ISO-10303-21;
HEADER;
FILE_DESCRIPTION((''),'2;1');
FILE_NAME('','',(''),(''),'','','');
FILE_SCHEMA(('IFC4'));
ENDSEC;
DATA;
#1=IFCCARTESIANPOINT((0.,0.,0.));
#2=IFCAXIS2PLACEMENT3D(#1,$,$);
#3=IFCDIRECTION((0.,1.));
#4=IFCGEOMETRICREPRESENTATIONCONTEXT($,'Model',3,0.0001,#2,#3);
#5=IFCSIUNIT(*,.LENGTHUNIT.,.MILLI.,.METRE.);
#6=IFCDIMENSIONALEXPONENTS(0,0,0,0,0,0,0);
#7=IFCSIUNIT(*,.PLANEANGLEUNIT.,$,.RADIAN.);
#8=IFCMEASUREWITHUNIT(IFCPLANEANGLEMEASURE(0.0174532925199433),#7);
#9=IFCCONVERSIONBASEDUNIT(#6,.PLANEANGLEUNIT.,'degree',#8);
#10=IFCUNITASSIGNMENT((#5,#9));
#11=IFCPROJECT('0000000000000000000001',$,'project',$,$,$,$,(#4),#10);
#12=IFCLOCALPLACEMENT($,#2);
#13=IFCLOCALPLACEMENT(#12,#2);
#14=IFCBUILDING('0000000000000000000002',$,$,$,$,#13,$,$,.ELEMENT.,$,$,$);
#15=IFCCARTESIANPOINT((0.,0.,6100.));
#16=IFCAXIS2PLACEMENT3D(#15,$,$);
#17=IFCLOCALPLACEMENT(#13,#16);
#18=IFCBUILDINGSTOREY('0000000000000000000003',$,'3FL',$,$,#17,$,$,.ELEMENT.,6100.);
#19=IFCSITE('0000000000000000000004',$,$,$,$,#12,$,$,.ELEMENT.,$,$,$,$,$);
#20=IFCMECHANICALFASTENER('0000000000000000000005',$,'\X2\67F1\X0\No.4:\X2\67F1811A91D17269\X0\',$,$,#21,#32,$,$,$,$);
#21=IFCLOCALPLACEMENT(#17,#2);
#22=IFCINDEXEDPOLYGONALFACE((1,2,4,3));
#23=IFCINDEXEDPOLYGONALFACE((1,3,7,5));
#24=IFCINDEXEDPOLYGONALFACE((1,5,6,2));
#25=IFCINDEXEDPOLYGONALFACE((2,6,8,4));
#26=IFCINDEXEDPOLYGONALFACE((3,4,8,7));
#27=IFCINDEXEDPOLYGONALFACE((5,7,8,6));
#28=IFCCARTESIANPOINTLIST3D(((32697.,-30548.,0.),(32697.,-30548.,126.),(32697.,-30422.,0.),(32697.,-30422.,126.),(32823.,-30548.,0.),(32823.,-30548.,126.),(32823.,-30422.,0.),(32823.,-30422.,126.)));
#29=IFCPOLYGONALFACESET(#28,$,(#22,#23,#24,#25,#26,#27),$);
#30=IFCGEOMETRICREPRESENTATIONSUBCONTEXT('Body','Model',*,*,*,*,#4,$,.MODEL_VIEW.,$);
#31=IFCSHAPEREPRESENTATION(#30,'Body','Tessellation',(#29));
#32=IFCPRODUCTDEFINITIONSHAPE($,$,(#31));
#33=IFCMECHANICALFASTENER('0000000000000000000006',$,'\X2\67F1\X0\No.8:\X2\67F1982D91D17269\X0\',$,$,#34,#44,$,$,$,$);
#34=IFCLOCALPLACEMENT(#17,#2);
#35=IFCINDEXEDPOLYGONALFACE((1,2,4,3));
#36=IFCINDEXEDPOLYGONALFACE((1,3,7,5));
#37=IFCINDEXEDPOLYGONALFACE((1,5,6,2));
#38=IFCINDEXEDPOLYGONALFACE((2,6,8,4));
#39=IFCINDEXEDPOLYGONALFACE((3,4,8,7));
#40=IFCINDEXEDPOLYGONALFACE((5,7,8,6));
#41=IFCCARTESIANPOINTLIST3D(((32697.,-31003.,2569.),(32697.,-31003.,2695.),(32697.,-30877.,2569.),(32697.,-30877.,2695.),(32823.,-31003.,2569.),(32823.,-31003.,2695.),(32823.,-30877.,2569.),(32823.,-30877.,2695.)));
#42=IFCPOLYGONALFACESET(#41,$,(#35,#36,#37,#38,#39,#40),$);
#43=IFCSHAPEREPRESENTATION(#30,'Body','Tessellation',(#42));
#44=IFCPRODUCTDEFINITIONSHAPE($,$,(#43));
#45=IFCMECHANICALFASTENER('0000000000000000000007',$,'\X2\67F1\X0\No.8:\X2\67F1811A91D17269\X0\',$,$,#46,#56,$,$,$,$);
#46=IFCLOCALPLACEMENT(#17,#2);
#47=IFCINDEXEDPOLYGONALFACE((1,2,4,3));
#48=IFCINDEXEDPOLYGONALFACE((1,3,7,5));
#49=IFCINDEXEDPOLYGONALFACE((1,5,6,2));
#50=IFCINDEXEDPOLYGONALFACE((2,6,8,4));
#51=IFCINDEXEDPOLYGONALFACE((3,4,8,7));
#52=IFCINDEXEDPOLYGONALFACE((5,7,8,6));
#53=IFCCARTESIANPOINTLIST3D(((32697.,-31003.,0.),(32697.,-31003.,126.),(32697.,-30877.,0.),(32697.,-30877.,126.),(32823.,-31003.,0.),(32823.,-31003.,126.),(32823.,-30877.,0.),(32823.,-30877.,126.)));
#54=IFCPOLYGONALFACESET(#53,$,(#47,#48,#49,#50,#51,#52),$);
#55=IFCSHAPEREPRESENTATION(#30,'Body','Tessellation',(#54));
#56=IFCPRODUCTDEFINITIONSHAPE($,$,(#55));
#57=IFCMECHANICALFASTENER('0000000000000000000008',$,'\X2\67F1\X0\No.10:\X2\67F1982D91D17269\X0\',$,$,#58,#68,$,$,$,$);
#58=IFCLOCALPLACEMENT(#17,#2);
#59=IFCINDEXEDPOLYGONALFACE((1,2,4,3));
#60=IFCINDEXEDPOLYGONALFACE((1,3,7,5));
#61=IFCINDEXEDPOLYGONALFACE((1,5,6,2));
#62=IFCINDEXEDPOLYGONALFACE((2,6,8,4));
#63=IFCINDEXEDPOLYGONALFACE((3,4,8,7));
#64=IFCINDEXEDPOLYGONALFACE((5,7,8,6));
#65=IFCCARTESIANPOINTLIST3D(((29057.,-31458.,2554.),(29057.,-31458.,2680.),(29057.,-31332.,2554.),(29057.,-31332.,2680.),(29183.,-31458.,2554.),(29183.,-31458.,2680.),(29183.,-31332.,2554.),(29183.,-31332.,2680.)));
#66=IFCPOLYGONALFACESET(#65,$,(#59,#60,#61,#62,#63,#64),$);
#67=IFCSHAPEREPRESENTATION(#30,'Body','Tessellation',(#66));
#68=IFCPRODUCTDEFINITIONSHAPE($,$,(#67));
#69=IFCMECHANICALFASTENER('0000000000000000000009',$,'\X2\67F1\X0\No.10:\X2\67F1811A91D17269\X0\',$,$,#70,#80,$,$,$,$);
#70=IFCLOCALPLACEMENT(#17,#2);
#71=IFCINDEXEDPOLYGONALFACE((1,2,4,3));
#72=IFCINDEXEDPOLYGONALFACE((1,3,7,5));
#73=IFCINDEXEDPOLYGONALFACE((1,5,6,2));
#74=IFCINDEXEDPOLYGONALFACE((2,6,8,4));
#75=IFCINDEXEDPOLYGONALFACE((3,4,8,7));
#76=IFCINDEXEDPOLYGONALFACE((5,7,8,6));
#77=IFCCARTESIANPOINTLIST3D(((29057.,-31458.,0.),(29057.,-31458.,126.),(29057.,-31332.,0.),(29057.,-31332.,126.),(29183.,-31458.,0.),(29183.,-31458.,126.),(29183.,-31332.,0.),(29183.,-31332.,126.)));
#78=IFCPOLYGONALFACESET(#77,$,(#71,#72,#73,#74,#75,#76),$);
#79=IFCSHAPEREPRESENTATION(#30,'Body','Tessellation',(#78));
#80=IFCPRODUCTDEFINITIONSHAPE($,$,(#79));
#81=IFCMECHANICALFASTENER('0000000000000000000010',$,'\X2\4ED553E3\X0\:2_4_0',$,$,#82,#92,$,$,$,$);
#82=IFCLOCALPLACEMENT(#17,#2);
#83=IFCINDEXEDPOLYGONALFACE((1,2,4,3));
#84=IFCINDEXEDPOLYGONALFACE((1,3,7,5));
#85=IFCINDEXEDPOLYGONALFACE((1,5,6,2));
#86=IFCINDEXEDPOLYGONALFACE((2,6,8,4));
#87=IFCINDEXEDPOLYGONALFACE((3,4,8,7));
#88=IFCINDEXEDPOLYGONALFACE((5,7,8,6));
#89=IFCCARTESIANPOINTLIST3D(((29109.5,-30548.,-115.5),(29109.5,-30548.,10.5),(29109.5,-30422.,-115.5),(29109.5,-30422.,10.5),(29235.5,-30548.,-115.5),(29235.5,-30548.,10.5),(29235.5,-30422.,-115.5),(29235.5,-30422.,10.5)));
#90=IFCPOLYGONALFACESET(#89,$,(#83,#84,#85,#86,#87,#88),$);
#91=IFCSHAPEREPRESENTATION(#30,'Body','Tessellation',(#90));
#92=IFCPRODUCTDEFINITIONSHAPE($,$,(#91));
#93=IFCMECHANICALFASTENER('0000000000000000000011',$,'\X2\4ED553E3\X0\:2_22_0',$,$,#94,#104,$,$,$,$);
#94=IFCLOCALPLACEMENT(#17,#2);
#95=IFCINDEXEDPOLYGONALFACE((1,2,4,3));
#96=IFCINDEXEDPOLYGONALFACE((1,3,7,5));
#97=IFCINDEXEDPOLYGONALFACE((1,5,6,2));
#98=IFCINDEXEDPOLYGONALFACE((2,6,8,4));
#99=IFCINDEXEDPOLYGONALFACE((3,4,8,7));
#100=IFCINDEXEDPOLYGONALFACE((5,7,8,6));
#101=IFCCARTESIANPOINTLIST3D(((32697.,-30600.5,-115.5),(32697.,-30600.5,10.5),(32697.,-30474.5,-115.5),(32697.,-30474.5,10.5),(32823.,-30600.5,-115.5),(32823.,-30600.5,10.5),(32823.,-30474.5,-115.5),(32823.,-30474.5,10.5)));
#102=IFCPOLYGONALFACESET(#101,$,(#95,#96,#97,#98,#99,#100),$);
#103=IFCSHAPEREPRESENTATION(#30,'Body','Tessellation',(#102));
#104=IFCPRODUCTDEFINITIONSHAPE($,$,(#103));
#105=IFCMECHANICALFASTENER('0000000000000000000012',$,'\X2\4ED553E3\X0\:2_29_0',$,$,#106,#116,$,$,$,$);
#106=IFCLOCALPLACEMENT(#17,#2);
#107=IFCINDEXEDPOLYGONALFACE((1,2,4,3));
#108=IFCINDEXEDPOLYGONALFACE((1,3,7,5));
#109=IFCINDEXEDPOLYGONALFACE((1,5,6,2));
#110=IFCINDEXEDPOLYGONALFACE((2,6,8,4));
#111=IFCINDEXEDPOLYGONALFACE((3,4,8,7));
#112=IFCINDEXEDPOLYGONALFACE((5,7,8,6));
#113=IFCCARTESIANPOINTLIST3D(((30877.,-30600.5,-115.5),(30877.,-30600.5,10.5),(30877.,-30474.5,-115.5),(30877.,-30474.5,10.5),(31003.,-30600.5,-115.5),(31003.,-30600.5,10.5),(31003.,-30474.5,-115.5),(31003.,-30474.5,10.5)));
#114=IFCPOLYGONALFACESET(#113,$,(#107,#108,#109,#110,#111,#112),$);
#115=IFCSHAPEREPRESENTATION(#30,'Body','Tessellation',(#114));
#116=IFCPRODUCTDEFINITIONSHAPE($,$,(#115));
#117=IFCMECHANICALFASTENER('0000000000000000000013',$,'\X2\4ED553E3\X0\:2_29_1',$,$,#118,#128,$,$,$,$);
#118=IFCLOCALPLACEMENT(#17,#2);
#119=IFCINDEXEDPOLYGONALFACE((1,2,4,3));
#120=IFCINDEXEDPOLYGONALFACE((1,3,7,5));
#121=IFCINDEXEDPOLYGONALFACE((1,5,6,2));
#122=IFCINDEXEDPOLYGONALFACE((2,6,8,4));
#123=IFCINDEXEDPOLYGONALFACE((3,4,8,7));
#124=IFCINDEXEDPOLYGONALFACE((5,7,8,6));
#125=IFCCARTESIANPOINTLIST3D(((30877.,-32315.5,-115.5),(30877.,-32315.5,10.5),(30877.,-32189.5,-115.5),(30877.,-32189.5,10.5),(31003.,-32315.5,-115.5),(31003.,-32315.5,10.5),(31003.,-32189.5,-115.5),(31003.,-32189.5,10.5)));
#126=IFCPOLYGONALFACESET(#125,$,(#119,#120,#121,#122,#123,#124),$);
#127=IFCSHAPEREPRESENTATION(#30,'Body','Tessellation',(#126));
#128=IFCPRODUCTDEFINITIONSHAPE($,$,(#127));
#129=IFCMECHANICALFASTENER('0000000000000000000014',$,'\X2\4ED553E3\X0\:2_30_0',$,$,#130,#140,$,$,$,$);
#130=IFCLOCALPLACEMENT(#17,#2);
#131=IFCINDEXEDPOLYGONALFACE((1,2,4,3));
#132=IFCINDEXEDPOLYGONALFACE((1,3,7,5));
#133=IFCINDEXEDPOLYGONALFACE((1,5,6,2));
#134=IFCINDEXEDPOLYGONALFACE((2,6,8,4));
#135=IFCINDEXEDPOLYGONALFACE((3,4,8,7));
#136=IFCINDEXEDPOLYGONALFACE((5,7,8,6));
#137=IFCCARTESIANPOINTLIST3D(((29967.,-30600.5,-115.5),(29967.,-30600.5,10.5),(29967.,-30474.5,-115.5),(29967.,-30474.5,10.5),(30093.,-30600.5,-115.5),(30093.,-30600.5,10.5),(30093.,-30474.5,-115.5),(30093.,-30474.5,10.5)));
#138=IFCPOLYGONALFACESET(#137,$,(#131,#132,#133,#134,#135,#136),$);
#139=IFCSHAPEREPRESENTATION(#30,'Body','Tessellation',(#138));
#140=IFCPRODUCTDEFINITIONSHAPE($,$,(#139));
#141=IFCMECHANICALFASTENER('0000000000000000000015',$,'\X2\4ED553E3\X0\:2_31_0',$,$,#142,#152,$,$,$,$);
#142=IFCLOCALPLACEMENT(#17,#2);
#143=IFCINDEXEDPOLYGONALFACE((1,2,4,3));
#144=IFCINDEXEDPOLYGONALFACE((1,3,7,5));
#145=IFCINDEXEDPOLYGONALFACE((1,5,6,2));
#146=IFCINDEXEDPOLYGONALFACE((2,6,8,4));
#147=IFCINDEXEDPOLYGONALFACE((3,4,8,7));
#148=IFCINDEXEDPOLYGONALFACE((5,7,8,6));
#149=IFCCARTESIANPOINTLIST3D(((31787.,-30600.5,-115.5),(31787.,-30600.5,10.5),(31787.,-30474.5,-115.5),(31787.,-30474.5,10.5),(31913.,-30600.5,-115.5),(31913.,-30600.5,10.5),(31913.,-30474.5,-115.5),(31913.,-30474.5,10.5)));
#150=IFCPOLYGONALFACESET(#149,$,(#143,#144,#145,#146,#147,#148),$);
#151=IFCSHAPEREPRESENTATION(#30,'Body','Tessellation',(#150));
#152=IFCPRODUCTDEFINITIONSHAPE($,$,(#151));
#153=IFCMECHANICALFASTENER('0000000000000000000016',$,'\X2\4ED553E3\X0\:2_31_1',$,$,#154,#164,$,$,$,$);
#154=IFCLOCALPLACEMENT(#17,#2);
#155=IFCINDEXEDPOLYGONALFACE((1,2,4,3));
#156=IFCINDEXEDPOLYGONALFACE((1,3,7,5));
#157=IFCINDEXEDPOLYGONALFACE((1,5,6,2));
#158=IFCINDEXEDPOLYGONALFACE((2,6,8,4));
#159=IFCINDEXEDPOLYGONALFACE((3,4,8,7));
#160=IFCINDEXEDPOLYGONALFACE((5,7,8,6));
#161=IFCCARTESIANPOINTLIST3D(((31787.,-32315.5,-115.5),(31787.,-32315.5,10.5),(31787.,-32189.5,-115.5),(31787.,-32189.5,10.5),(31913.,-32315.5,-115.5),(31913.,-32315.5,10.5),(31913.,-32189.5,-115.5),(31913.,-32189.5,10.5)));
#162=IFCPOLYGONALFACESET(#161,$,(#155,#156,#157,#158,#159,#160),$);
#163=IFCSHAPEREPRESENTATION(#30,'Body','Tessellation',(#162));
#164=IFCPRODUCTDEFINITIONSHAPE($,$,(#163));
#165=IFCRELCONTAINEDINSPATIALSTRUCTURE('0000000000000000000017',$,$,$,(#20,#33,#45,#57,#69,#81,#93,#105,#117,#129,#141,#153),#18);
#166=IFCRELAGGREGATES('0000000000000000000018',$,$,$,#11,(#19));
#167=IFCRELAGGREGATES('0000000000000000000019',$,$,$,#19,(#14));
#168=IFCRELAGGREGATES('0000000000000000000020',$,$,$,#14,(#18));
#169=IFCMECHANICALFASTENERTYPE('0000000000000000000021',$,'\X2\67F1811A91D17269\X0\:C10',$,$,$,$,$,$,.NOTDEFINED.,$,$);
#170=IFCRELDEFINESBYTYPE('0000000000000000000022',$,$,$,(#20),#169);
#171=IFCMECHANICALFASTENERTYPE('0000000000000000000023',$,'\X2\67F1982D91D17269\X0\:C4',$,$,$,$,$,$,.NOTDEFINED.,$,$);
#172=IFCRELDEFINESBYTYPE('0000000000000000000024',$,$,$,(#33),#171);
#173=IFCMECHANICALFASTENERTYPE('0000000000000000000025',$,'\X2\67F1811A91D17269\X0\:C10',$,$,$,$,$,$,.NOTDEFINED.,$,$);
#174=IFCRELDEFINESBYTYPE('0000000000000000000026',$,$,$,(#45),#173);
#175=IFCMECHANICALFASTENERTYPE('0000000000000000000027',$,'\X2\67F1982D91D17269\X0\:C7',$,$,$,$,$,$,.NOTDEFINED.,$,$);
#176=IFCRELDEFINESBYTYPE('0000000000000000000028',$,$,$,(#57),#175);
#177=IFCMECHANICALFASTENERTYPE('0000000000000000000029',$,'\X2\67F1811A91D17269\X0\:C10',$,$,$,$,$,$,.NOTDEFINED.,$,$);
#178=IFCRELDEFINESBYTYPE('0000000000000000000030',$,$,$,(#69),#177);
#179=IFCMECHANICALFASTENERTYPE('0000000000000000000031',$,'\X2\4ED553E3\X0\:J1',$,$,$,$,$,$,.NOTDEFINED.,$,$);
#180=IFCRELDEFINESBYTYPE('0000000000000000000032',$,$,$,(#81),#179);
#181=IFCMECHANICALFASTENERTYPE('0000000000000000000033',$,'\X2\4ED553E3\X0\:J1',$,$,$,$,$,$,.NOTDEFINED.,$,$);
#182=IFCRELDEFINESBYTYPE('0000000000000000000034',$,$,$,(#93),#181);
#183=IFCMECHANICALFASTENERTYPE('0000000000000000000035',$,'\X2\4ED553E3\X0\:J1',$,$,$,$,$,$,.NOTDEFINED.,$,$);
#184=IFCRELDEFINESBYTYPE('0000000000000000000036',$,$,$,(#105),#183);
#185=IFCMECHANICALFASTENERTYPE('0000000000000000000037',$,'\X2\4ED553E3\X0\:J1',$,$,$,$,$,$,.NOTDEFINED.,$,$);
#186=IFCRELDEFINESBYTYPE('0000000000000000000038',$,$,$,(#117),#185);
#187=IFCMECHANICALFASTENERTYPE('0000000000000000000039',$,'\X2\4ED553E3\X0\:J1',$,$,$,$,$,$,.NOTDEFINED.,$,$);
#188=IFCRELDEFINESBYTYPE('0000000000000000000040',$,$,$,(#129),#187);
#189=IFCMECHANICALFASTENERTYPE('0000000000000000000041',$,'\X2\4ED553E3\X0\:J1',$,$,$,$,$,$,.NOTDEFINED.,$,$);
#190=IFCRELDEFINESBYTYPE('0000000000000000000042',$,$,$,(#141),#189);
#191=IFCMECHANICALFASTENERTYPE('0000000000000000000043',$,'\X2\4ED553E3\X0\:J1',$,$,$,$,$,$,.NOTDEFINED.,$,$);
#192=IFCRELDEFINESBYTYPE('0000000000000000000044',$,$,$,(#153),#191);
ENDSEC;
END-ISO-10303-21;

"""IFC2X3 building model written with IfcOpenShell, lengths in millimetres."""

from ifc_helpers import new_model, entity, si_unit, converted_unit, direction, frame, origin, origin_with_axes, origin_2d, place, context, subcontext, project, spatial, rectangle, extrude, type_object, element, save


model = new_model("IFC2X3")

# Units and contexts
model_context = context("Model", 3, precision=0.0001, world=origin(), true_north=direction((0.0, 1.0)))
body_context = subcontext(model_context, "Body", "Model", "MODEL_VIEW")
ifc_project = project(units=[si_unit("LENGTHUNIT", "METRE", prefix="MILLI"), converted_unit("PLANEANGLEUNIT", "degree", entity("IfcPlaneAngleMeasure", 0.0174532925199433), si_unit("PLANEANGLEUNIT", "RADIAN"), dimensions=[0, 0, 0, 0, 0, 0, 0])], contexts=[model_context])

# Site, building, storey
site_placement = place(None, origin())
site = spatial("IfcSite", under=ifc_project, at=site_placement, CompositionType="ELEMENT")
building_placement = place(site_placement, origin())
building = spatial("IfcBuilding", under=site, at=building_placement, CompositionType="ELEMENT")
storey_placement = place(building_placement, frame((0.0, 0.0, 6100.0)))
storey = spatial("IfcBuildingStorey", under=building, at=storey_placement, Name="3FL", CompositionType="ELEMENT", Elevation=6100.0)

# Mechanical fasteners
mechanical_fastener_type_1 = type_object("IfcMechanicalFastenerType", Name="柱脚金物:C10")
mechanical_fastener_1_placement = place(storey_placement, frame((32760.0, -30485.0, 0.0)))
element("IfcMechanicalFastener", 1, at=mechanical_fastener_1_placement, inside=storey, type_object=mechanical_fastener_type_1, Name="柱No.4:柱脚金物", context=body_context, shape_type="SweptSolid", body=[
    extrude(rectangle(XDim=126.0, YDim=126.0, at=origin_2d()), origin_with_axes(), (0.0, 0.0, 1.0), 126.0),
])
mechanical_fastener_type_2 = type_object("IfcMechanicalFastenerType", Name="柱頭金物:C4")
mechanical_fastener_2_placement = place(storey_placement, frame((32760.0, -30940.0, 2569.0)))
element("IfcMechanicalFastener", 2, at=mechanical_fastener_2_placement, inside=storey, type_object=mechanical_fastener_type_2, Name="柱No.8:柱頭金物", context=body_context, shape_type="SweptSolid", body=[
    extrude(rectangle(XDim=126.0, YDim=126.0, at=origin_2d()), origin_with_axes(), (0.0, 0.0, 1.0), 126.0),
])
mechanical_fastener_type_3 = type_object("IfcMechanicalFastenerType", Name="柱脚金物:C10")
mechanical_fastener_3_placement = place(storey_placement, frame((32760.0, -30940.0, 0.0)))
element("IfcMechanicalFastener", 3, at=mechanical_fastener_3_placement, inside=storey, type_object=mechanical_fastener_type_3, Name="柱No.8:柱脚金物", context=body_context, shape_type="SweptSolid", body=[
    extrude(rectangle(XDim=126.0, YDim=126.0, at=origin_2d()), origin_with_axes(), (0.0, 0.0, 1.0), 126.0),
])
mechanical_fastener_type_4 = type_object("IfcMechanicalFastenerType", Name="柱頭金物:C7")
mechanical_fastener_4_placement = place(storey_placement, frame((29120.0, -31395.0, 2554.0)))
element("IfcMechanicalFastener", 4, at=mechanical_fastener_4_placement, inside=storey, type_object=mechanical_fastener_type_4, Name="柱No.10:柱頭金物", context=body_context, shape_type="SweptSolid", body=[
    extrude(rectangle(XDim=126.0, YDim=126.0, at=origin_2d()), origin_with_axes(), (0.0, 0.0, 1.0), 126.0),
])
mechanical_fastener_type_5 = type_object("IfcMechanicalFastenerType", Name="柱脚金物:C10")
mechanical_fastener_5_placement = place(storey_placement, frame((29120.0, -31395.0, 0.0)))
element("IfcMechanicalFastener", 5, at=mechanical_fastener_5_placement, inside=storey, type_object=mechanical_fastener_type_5, Name="柱No.10:柱脚金物", context=body_context, shape_type="SweptSolid", body=[
    extrude(rectangle(XDim=126.0, YDim=126.0, at=origin_2d()), origin_with_axes(), (0.0, 0.0, 1.0), 126.0),
])
mechanical_fastener_type_6 = type_object("IfcMechanicalFastenerType", Name="仕口:J1")
mechanical_fastener_6_placement = place(storey_placement, frame((29172.5, -30485.0, -115.5)))
element("IfcMechanicalFastener", 6, at=mechanical_fastener_6_placement, inside=storey, type_object=mechanical_fastener_type_6, Name="仕口:2_4_0", context=body_context, shape_type="SweptSolid", body=[
    extrude(rectangle(XDim=126.0, YDim=126.0, at=origin_2d()), origin_with_axes(), (0.0, 0.0, 1.0), 126.0),
])
mechanical_fastener_type_7 = type_object("IfcMechanicalFastenerType", Name="仕口:J1")
mechanical_fastener_7_placement = place(storey_placement, frame((32760.0, -30537.5, -115.5)))
element("IfcMechanicalFastener", 7, at=mechanical_fastener_7_placement, inside=storey, type_object=mechanical_fastener_type_7, Name="仕口:2_22_0", context=body_context, shape_type="SweptSolid", body=[
    extrude(rectangle(XDim=126.0, YDim=126.0, at=origin_2d()), origin_with_axes(), (0.0, 0.0, 1.0), 126.0),
])
mechanical_fastener_type_8 = type_object("IfcMechanicalFastenerType", Name="仕口:J1")
mechanical_fastener_8_placement = place(storey_placement, frame((30940.0, -30537.5, -115.5)))
element("IfcMechanicalFastener", 8, at=mechanical_fastener_8_placement, inside=storey, type_object=mechanical_fastener_type_8, Name="仕口:2_29_0", context=body_context, shape_type="SweptSolid", body=[
    extrude(rectangle(XDim=126.0, YDim=126.0, at=origin_2d()), origin_with_axes(), (0.0, 0.0, 1.0), 126.0),
])
mechanical_fastener_type_9 = type_object("IfcMechanicalFastenerType", Name="仕口:J1")
mechanical_fastener_9_placement = place(storey_placement, frame((30940.0, -32252.5, -115.5)))
element("IfcMechanicalFastener", 9, at=mechanical_fastener_9_placement, inside=storey, type_object=mechanical_fastener_type_9, Name="仕口:2_29_1", context=body_context, shape_type="SweptSolid", body=[
    extrude(rectangle(XDim=126.0, YDim=126.0, at=origin_2d()), origin_with_axes(), (0.0, 0.0, 1.0), 126.0),
])
mechanical_fastener_type_10 = type_object("IfcMechanicalFastenerType", Name="仕口:J1")
mechanical_fastener_10_placement = place(storey_placement, frame((30030.0, -30537.5, -115.5)))
element("IfcMechanicalFastener", 10, at=mechanical_fastener_10_placement, inside=storey, type_object=mechanical_fastener_type_10, Name="仕口:2_30_0", context=body_context, shape_type="SweptSolid", body=[
    extrude(rectangle(XDim=126.0, YDim=126.0, at=origin_2d()), origin_with_axes(), (0.0, 0.0, 1.0), 126.0),
])
mechanical_fastener_type_11 = type_object("IfcMechanicalFastenerType", Name="仕口:J1")
mechanical_fastener_11_placement = place(storey_placement, frame((31850.0, -30537.5, -115.5)))
element("IfcMechanicalFastener", 11, at=mechanical_fastener_11_placement, inside=storey, type_object=mechanical_fastener_type_11, Name="仕口:2_31_0", context=body_context, shape_type="SweptSolid", body=[
    extrude(rectangle(XDim=126.0, YDim=126.0, at=origin_2d()), origin_with_axes(), (0.0, 0.0, 1.0), 126.0),
])
mechanical_fastener_type_12 = type_object("IfcMechanicalFastenerType", Name="仕口:J1")
mechanical_fastener_12_placement = place(storey_placement, frame((31850.0, -32252.5, -115.5)))
element("IfcMechanicalFastener", 12, at=mechanical_fastener_12_placement, inside=storey, type_object=mechanical_fastener_type_12, Name="仕口:2_31_1", context=body_context, shape_type="SweptSolid", body=[
    extrude(rectangle(XDim=126.0, YDim=126.0, at=origin_2d()), origin_with_axes(), (0.0, 0.0, 1.0), 126.0),
])

save(model, "model.ifc")
